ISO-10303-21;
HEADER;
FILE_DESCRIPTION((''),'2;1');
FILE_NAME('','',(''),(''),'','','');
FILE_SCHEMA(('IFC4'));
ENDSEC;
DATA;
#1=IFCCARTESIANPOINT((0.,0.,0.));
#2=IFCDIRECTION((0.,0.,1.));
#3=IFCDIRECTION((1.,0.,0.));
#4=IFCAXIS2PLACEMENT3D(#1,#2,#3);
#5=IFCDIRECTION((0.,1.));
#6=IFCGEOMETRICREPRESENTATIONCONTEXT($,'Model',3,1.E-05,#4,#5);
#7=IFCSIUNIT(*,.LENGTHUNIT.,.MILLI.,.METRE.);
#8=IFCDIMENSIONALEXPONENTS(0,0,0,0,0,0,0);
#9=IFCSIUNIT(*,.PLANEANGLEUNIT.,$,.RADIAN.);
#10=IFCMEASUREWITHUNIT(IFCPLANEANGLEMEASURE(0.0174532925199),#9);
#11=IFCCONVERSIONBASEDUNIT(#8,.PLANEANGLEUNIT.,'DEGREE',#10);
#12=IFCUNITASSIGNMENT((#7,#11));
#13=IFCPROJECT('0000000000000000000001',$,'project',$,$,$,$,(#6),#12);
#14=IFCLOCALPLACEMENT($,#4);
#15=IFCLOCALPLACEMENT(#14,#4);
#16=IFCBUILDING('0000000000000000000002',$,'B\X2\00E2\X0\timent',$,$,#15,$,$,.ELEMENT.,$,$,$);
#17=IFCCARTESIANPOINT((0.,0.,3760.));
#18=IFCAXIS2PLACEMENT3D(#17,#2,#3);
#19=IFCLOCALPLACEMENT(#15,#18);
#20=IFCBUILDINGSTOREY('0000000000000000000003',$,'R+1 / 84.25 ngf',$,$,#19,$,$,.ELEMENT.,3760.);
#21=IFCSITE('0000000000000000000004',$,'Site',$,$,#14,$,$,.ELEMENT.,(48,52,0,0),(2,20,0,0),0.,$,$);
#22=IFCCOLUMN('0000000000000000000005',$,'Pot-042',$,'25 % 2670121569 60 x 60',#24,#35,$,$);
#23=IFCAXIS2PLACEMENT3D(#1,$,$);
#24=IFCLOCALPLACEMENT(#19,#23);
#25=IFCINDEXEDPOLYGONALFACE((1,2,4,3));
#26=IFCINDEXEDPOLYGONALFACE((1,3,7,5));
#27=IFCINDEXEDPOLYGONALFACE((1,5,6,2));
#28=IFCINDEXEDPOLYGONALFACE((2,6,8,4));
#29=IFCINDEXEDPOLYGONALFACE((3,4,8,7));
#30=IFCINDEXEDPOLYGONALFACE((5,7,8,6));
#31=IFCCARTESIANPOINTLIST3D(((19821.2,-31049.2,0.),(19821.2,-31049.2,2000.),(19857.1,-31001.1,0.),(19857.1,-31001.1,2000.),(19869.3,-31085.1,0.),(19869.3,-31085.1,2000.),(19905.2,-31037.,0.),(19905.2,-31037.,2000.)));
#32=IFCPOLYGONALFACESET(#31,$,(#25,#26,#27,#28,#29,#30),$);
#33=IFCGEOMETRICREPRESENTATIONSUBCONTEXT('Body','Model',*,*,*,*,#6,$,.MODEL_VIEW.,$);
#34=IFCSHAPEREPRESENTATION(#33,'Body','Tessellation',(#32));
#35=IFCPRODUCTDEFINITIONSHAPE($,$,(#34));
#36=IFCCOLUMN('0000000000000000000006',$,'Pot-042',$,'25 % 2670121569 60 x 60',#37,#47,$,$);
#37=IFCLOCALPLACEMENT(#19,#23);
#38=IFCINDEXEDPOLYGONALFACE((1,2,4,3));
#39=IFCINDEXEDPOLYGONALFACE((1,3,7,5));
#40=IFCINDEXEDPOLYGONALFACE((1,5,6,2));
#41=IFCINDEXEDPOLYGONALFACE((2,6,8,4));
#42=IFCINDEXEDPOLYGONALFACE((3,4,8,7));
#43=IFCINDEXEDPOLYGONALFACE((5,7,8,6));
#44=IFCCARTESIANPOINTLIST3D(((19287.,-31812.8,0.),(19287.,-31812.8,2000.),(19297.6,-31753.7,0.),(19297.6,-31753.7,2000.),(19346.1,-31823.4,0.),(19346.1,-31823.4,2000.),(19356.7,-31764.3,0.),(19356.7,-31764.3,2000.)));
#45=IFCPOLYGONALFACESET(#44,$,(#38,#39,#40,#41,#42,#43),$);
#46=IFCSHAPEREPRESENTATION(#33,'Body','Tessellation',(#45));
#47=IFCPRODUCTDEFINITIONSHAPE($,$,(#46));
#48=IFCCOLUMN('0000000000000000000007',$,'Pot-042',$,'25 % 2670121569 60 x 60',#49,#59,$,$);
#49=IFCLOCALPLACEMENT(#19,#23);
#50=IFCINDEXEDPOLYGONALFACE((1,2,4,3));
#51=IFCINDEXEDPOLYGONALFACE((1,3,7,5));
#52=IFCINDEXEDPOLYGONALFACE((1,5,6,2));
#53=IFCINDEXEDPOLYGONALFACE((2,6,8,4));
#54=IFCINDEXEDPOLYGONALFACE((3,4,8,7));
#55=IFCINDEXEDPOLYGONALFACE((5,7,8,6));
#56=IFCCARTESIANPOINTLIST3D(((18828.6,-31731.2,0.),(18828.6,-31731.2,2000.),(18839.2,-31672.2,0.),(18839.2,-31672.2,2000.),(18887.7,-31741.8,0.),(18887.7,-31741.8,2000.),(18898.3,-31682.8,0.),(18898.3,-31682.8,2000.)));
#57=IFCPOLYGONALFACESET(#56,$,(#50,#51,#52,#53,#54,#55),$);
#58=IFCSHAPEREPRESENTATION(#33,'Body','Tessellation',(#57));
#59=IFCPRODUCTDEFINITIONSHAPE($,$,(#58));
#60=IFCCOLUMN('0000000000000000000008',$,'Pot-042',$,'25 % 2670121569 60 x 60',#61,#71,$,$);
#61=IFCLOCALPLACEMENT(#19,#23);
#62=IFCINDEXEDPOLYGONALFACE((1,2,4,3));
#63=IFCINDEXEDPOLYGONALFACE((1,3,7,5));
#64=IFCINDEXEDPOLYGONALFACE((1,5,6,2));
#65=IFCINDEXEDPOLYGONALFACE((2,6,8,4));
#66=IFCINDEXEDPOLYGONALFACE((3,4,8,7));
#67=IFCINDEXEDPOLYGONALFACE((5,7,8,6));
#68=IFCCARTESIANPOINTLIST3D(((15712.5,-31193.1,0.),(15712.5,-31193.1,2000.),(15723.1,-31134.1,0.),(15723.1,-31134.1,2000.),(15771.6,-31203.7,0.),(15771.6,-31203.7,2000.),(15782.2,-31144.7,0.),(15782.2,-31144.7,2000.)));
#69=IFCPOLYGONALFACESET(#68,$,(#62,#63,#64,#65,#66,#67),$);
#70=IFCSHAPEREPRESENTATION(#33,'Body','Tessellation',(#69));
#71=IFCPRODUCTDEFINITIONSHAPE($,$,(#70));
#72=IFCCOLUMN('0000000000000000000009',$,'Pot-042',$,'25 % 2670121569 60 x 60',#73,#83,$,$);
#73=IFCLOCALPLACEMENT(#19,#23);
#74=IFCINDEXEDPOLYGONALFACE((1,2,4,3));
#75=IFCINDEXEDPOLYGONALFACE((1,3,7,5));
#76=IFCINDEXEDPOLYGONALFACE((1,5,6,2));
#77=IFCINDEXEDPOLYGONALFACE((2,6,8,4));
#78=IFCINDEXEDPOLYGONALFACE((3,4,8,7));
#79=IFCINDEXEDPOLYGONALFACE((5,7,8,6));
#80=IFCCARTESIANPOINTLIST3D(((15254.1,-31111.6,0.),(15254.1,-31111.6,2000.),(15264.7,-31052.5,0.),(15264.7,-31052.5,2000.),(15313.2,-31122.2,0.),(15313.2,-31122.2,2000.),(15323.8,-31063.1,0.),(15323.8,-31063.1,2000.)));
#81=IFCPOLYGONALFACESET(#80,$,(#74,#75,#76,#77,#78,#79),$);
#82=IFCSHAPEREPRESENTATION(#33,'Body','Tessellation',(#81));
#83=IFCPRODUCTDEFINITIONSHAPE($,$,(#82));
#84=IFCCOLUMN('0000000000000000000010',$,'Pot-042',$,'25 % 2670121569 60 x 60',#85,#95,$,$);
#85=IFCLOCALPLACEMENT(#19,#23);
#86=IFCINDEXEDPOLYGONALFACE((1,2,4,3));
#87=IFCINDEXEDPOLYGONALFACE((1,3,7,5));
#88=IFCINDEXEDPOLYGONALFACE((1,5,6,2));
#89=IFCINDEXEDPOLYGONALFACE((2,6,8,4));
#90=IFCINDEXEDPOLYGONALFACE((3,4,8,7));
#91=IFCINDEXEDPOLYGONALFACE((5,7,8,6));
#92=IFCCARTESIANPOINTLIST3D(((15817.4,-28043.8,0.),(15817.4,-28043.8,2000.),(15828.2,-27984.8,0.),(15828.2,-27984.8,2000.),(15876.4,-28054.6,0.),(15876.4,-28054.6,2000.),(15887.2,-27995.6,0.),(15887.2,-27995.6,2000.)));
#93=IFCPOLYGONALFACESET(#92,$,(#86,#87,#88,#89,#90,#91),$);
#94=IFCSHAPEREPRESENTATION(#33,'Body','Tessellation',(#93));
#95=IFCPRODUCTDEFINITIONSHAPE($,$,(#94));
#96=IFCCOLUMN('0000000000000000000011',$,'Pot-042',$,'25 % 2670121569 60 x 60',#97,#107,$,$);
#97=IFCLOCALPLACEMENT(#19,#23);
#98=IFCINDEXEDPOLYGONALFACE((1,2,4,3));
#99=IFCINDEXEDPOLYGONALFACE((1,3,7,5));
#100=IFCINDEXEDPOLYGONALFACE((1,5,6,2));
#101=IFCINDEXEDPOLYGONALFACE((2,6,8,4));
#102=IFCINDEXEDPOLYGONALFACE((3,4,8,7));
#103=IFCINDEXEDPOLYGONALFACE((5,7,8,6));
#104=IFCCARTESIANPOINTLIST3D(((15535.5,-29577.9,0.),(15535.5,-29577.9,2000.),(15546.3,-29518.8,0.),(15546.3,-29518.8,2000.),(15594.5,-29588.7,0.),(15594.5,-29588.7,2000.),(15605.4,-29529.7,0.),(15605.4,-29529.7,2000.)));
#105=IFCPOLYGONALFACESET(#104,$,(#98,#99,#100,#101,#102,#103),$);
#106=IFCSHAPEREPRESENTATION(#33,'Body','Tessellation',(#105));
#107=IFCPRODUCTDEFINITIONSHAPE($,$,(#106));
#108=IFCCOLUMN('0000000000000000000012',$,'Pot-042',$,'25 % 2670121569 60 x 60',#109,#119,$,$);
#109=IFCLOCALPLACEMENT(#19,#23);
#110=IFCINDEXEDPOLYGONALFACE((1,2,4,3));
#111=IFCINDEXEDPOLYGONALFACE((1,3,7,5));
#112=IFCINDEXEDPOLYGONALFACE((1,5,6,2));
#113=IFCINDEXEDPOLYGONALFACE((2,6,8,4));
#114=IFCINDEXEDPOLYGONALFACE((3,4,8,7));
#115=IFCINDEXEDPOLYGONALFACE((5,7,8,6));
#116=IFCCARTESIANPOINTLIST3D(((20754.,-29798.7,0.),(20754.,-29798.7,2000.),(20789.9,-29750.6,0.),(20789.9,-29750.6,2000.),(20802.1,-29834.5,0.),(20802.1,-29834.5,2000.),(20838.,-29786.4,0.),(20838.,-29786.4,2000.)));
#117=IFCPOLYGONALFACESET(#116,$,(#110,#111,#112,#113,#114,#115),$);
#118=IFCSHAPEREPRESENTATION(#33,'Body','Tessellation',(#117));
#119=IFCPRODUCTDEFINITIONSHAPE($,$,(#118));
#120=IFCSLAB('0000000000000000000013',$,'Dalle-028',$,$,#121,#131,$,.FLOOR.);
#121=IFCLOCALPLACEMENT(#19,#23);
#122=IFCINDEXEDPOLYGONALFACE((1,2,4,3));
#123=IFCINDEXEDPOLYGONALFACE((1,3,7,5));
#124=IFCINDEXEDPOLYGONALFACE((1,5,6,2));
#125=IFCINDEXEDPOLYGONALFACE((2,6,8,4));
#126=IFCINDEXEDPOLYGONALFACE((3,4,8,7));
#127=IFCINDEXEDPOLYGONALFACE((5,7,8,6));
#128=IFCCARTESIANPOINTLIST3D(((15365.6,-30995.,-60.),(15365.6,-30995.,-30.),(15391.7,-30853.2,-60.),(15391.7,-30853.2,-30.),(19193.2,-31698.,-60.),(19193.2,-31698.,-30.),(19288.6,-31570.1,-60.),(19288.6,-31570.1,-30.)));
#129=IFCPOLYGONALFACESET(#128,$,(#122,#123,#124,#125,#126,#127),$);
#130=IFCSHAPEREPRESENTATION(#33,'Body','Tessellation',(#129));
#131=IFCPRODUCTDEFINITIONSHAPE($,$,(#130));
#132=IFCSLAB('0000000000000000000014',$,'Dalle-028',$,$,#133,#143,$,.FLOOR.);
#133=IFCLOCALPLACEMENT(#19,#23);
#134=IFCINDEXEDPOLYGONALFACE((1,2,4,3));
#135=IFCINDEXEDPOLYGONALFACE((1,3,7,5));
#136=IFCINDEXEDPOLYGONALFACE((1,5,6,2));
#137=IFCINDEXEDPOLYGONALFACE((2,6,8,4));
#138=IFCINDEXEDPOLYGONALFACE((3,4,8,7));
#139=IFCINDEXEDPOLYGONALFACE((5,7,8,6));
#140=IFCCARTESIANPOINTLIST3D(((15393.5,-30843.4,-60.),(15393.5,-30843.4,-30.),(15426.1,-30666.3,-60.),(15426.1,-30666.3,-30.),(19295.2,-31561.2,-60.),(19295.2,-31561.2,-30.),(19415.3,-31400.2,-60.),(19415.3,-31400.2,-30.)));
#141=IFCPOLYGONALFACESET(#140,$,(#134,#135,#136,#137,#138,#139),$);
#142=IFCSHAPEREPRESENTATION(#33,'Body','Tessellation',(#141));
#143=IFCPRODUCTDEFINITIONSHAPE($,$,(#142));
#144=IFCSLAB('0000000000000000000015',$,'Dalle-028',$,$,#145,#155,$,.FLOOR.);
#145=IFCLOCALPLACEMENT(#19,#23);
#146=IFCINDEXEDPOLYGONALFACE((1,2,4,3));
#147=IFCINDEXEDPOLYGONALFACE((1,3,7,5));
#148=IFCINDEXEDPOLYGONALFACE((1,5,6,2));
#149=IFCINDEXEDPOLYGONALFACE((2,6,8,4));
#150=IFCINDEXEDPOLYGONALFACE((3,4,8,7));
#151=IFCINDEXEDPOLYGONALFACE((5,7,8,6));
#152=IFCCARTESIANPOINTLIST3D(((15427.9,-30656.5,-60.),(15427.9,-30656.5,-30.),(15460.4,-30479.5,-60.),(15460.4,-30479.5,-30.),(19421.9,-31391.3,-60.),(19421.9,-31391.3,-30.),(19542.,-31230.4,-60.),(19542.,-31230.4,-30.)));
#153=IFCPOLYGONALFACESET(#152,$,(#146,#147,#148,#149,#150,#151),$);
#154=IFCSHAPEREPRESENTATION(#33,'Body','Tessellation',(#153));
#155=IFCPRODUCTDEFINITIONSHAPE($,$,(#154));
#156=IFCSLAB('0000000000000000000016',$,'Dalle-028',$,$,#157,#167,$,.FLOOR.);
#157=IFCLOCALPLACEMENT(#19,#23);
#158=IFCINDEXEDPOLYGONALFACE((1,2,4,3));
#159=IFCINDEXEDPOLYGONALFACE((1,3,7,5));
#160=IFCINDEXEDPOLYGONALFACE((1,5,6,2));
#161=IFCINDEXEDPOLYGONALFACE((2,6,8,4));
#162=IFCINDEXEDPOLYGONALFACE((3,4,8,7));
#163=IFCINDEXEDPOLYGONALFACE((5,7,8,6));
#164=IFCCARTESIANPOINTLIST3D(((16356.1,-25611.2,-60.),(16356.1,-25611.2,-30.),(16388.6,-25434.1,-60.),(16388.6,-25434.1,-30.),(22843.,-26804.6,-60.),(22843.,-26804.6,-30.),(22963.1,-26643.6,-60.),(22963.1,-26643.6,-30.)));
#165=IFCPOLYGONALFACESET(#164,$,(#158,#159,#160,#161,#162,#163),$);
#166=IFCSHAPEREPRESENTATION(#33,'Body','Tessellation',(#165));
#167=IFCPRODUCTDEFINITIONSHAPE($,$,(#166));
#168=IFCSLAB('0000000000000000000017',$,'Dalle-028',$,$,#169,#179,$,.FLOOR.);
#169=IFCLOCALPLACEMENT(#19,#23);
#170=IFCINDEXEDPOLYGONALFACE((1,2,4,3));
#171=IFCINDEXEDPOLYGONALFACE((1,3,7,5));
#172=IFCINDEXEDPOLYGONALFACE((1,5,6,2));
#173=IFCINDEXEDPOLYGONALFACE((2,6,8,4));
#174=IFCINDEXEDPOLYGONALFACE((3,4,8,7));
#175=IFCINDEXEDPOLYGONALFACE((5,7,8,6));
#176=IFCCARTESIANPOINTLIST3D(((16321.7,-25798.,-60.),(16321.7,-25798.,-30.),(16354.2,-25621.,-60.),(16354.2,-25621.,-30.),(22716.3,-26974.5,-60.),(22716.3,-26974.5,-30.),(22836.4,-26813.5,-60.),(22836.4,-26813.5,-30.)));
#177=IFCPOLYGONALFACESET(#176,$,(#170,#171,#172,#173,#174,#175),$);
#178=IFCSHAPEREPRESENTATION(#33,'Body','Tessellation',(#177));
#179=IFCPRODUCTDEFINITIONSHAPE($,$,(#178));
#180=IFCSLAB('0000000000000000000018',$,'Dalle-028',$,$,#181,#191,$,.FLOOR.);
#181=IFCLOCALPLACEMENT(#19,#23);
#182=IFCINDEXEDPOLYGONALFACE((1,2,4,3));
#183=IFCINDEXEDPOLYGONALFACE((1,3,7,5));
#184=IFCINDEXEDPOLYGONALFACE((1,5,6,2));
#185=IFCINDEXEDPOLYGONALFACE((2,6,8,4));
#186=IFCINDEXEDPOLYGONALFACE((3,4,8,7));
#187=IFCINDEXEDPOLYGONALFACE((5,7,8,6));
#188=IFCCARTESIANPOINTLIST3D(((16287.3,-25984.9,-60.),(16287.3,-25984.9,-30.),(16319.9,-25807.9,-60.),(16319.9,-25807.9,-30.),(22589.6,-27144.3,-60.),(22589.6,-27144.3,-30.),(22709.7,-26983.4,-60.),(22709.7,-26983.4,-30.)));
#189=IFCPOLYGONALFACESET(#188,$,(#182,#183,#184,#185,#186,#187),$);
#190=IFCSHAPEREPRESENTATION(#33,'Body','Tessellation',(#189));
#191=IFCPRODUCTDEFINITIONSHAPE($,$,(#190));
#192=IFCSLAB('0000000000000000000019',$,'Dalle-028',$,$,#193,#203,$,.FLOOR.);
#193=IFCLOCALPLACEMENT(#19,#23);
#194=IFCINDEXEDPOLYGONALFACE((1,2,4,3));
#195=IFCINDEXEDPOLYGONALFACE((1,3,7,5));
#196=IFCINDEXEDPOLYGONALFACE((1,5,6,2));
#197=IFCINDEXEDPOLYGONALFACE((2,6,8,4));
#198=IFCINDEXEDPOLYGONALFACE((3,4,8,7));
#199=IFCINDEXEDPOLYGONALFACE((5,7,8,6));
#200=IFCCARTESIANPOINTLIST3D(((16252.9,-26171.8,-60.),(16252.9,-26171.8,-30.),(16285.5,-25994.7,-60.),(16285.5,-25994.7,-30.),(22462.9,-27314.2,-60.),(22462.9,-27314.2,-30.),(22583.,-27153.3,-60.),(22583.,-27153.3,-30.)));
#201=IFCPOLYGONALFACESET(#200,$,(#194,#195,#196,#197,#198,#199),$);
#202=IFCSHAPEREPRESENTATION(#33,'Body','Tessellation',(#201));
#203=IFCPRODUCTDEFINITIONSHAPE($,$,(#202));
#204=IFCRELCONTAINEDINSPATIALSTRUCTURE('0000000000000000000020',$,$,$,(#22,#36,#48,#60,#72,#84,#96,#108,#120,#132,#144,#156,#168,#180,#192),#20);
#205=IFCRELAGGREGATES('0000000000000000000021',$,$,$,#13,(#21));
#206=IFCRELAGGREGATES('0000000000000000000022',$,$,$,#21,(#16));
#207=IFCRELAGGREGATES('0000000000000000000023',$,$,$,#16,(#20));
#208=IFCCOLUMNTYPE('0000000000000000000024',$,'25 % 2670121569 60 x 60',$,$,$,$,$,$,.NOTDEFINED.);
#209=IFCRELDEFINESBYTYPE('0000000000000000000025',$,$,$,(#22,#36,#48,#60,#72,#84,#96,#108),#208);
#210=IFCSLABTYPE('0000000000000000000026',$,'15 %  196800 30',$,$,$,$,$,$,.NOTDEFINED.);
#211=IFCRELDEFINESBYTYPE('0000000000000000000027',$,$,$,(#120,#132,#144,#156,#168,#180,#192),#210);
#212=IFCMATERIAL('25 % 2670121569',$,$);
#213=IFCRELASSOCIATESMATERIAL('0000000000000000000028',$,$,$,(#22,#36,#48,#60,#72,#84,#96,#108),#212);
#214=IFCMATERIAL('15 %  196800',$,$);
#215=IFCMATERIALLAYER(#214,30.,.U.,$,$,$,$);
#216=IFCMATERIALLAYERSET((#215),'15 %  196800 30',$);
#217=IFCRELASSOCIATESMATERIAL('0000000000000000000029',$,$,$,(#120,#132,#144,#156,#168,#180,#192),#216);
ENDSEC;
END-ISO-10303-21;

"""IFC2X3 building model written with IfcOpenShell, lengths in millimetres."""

from ifc_helpers import new_model, entity, si_unit, converted_unit, direction, frame, origin_with_axes, origin_2d_with_axis, place, context, subcontext, project, spatial, polyline, rectangle, outline, extrude, material, layer, layer_set, layer_usage, type_object, element, save


model = new_model("IFC2X3")

# Units and contexts
model_context = context("Model", 3, precision=1e-05, world=origin_with_axes(), true_north=direction((0.0, 1.0)))
body_context = subcontext(model_context, "Body", "Model", "MODEL_VIEW")
ifc_project = project(units=[si_unit("LENGTHUNIT", "METRE", prefix="MILLI"), converted_unit("PLANEANGLEUNIT", "DEGREE", entity("IfcPlaneAngleMeasure", 0.0174532925199), si_unit("PLANEANGLEUNIT", "RADIAN"), dimensions=[0, 0, 0, 0, 0, 0, 0])], contexts=[model_context])

# Site, building, storey
site_placement = place(None, origin_with_axes())
site = spatial("IfcSite", under=ifc_project, at=site_placement, Name="Site", CompositionType="ELEMENT", RefLatitude=(48, 52, 0, 0), RefLongitude=(2, 20, 0, 0), RefElevation=0.0)
building_placement = place(site_placement, origin_with_axes())
building = spatial("IfcBuilding", under=site, at=building_placement, Name="Bâtiment", CompositionType="ELEMENT")
storey_placement = place(building_placement, frame((0.0, 0.0, 3760.0), z_axis=(0.0, 0.0, 1.0), x_axis=(1.0, 0.0, 0.0)))
storey = spatial("IfcBuildingStorey", under=building, at=storey_placement, Name="R+1 / 84.25 ngf", CompositionType="ELEMENT", Elevation=3760.0)

# Columns
ifc_material_1 = material(Name="25 % 2670121569")
column_type = type_object("IfcColumnType", Name="25 % 2670121569 60 x 60", PredefinedType="NOTDEFINED")
for number, where, z_axis, x_axis, name in (
    (1, (19863.2, -31043.1, 0.0), (0.0, 0.0, 1.0), (0.801586, -0.597879, 0.0), "Pot-042"),
    (2, (19321.9, -31788.5, 0.0), (0.0, 0.0, 1.0), (-0.176757, -0.984255, 0.0), "Pot-042"),
    (3, (18863.4, -31707.0, 0.0), (0.0, 0.0, 1.0), (-0.176757, -0.984255, 0.0), "Pot-042"),
    (4, (15747.4, -31168.9, 0.0), (0.0, 0.0, 1.0), (-0.176757, -0.984255, 0.0), "Pot-042"),
    (5, (15288.9, -31087.3, 0.0), (0.0, 0.0, 1.0), (-0.176757, -0.984255, 0.0), "Pot-042"),
    (6, (15852.3, -28019.7, 0.0), (0.0, 0.0, 1.0), (0.983606, -0.180333, 0.0), "Pot-042"),
    (7, (15570.4, -29553.8, 0.0), (0.0, 0.0, 1.0), (0.983606, -0.180333, 0.0), "Pot-042"),
    (8, (20796.0, -29792.5, 0.0), (0.0, 0.0, 1.0), (0.801586, -0.597879, 0.0), "Pot-042"),
):
    element("IfcColumn", number, at=place(storey_placement, frame(where, z_axis=z_axis, x_axis=x_axis)), inside=storey, type_object=column_type, material=ifc_material_1, Name=name, ObjectType="25 % 2670121569 60 x 60", context=body_context, shape_type="SweptSolid", body=[
        extrude(rectangle(XDim=60.0, YDim=60.0, at=origin_2d_with_axis()), origin_with_axes(), (0.0, 0.0, 1.0), 2000.0),
    ])

# Slabs
ifc_material_2 = material(Name="15 %  196800")
ifc_layer_1 = layer(ifc_material_2, 30.0, ventilated="UNKNOWN")
ifc_layer_set_1 = layer_set([ifc_layer_1], Name="15 %  196800 30")
ifc_layer_usage_1 = layer_usage(ifc_layer_set_1, "AXIS3", "NEGATIVE", 30.0)
slab_type = type_object("IfcSlabType", Name="15 %  196800 30", PredefinedType="NOTDEFINED")
slab_1_placement = place(storey_placement, frame((15391.7, -30853.2, -30.0), z_axis=(0.0, 0.0, 1.0), x_axis=(1.0, 0.0, 0.0)))
element("IfcSlab", 9, at=slab_1_placement, inside=storey, type_object=slab_type, material=ifc_layer_usage_1, Name="Dalle-028", PredefinedType="FLOOR", context=body_context, shape_type="SweptSolid", body=[
    extrude(outline(polyline([(0.0, 0.0), (-26.1, -141.8), (3801.5, -844.8), (3896.9, -716.9), (0.0, 0.0)])), frame((0.0, 0.0, -30.0), z_axis=(0.0, 0.0, 1.0), x_axis=(1.0, 0.0, 0.0)), (0.0, 0.0, 1.0), 30.0),
])
ifc_layer_usage_2 = layer_usage(ifc_layer_set_1, "AXIS3", "NEGATIVE", 30.0)
slab_2_placement = place(storey_placement, frame((15426.1, -30666.3, -30.0), z_axis=(0.0, 0.0, 1.0), x_axis=(1.0, 0.0, 0.0)))
element("IfcSlab", 10, at=slab_2_placement, inside=storey, type_object=slab_type, material=ifc_layer_usage_2, Name="Dalle-028", PredefinedType="FLOOR", context=body_context, shape_type="SweptSolid", body=[
    extrude(outline(polyline([(0.0, 0.0), (-32.6, -177.0), (3869.2, -894.8), (3989.2, -733.9), (0.0, 0.0)])), frame((0.0, 0.0, -30.0), z_axis=(0.0, 0.0, 1.0), x_axis=(1.0, 0.0, 0.0)), (0.0, 0.0, 1.0), 30.0),
])
ifc_layer_usage_3 = layer_usage(ifc_layer_set_1, "AXIS3", "NEGATIVE", 30.0)
slab_3_placement = place(storey_placement, frame((15460.4, -30479.5, -30.0), z_axis=(0.0, 0.0, 1.0), x_axis=(1.0, 0.0, 0.0)))
element("IfcSlab", 11, at=slab_3_placement, inside=storey, type_object=slab_type, material=ifc_layer_usage_3, Name="Dalle-028", PredefinedType="FLOOR", context=body_context, shape_type="SweptSolid", body=[
    extrude(outline(polyline([(0.0, 0.0), (-32.6, -177.0), (3961.5, -911.8), (4081.5, -750.9), (0.0, 0.0)])), frame((0.0, 0.0, -30.0), z_axis=(0.0, 0.0, 1.0), x_axis=(1.0, 0.0, 0.0)), (0.0, 0.0, 1.0), 30.0),
])
ifc_layer_usage_4 = layer_usage(ifc_layer_set_1, "AXIS3", "NEGATIVE", 30.0)
slab_4_placement = place(storey_placement, frame((16388.6, -25434.1, -30.0), z_axis=(0.0, 0.0, 1.0), x_axis=(1.0, 0.0, 0.0)))
element("IfcSlab", 12, at=slab_4_placement, inside=storey, type_object=slab_type, material=ifc_layer_usage_4, Name="Dalle-028", PredefinedType="FLOOR", context=body_context, shape_type="SweptSolid", body=[
    extrude(outline(polyline([(0.0, 0.0), (-32.6, -177.0), (6454.4, -1370.4), (6574.4, -1209.5), (0.0, 0.0)])), frame((0.0, 0.0, -30.0), z_axis=(0.0, 0.0, 1.0), x_axis=(1.0, 0.0, 0.0)), (0.0, 0.0, 1.0), 30.0),
])
ifc_layer_usage_5 = layer_usage(ifc_layer_set_1, "AXIS3", "NEGATIVE", 30.0)
slab_5_placement = place(storey_placement, frame((16354.2, -25621.0, -30.0), z_axis=(0.0, 0.0, 1.0), x_axis=(1.0, 0.0, 0.0)))
element("IfcSlab", 13, at=slab_5_placement, inside=storey, type_object=slab_type, material=ifc_layer_usage_5, Name="Dalle-028", PredefinedType="FLOOR", context=body_context, shape_type="SweptSolid", body=[
    extrude(outline(polyline([(0.0, 0.0), (-32.6, -177.0), (6362.1, -1353.4), (6482.1, -1192.5), (0.0, 0.0)])), frame((0.0, 0.0, -30.0), z_axis=(0.0, 0.0, 1.0), x_axis=(1.0, 0.0, 0.0)), (0.0, 0.0, 1.0), 30.0),
])
ifc_layer_usage_6 = layer_usage(ifc_layer_set_1, "AXIS3", "NEGATIVE", 30.0)
slab_6_placement = place(storey_placement, frame((16319.9, -25807.9, -30.0), z_axis=(0.0, 0.0, 1.0), x_axis=(1.0, 0.0, 0.0)))
element("IfcSlab", 14, at=slab_6_placement, inside=storey, type_object=slab_type, material=ifc_layer_usage_6, Name="Dalle-028", PredefinedType="FLOOR", context=body_context, shape_type="SweptSolid", body=[
    extrude(outline(polyline([(0.0, 0.0), (-32.6, -177.0), (6269.8, -1336.5), (6389.8, -1175.5), (0.0, 0.0)])), frame((0.0, 0.0, -30.0), z_axis=(0.0, 0.0, 1.0), x_axis=(1.0, 0.0, 0.0)), (0.0, 0.0, 1.0), 30.0),
])
ifc_layer_usage_7 = layer_usage(ifc_layer_set_1, "AXIS3", "NEGATIVE", 30.0)
slab_7_placement = place(storey_placement, frame((16285.5, -25994.7, -30.0), z_axis=(0.0, 0.0, 1.0), x_axis=(1.0, 0.0, 0.0)))
element("IfcSlab", 15, at=slab_7_placement, inside=storey, type_object=slab_type, material=ifc_layer_usage_7, Name="Dalle-028", PredefinedType="FLOOR", context=body_context, shape_type="SweptSolid", body=[
    extrude(outline(polyline([(0.0, 0.0), (-32.6, -177.0), (6177.4, -1319.5), (6297.5, -1158.5), (0.0, 0.0)])), frame((0.0, 0.0, -30.0), z_axis=(0.0, 0.0, 1.0), x_axis=(1.0, 0.0, 0.0)), (0.0, 0.0, 1.0), 30.0),
])

save(model, "model.ifc")
